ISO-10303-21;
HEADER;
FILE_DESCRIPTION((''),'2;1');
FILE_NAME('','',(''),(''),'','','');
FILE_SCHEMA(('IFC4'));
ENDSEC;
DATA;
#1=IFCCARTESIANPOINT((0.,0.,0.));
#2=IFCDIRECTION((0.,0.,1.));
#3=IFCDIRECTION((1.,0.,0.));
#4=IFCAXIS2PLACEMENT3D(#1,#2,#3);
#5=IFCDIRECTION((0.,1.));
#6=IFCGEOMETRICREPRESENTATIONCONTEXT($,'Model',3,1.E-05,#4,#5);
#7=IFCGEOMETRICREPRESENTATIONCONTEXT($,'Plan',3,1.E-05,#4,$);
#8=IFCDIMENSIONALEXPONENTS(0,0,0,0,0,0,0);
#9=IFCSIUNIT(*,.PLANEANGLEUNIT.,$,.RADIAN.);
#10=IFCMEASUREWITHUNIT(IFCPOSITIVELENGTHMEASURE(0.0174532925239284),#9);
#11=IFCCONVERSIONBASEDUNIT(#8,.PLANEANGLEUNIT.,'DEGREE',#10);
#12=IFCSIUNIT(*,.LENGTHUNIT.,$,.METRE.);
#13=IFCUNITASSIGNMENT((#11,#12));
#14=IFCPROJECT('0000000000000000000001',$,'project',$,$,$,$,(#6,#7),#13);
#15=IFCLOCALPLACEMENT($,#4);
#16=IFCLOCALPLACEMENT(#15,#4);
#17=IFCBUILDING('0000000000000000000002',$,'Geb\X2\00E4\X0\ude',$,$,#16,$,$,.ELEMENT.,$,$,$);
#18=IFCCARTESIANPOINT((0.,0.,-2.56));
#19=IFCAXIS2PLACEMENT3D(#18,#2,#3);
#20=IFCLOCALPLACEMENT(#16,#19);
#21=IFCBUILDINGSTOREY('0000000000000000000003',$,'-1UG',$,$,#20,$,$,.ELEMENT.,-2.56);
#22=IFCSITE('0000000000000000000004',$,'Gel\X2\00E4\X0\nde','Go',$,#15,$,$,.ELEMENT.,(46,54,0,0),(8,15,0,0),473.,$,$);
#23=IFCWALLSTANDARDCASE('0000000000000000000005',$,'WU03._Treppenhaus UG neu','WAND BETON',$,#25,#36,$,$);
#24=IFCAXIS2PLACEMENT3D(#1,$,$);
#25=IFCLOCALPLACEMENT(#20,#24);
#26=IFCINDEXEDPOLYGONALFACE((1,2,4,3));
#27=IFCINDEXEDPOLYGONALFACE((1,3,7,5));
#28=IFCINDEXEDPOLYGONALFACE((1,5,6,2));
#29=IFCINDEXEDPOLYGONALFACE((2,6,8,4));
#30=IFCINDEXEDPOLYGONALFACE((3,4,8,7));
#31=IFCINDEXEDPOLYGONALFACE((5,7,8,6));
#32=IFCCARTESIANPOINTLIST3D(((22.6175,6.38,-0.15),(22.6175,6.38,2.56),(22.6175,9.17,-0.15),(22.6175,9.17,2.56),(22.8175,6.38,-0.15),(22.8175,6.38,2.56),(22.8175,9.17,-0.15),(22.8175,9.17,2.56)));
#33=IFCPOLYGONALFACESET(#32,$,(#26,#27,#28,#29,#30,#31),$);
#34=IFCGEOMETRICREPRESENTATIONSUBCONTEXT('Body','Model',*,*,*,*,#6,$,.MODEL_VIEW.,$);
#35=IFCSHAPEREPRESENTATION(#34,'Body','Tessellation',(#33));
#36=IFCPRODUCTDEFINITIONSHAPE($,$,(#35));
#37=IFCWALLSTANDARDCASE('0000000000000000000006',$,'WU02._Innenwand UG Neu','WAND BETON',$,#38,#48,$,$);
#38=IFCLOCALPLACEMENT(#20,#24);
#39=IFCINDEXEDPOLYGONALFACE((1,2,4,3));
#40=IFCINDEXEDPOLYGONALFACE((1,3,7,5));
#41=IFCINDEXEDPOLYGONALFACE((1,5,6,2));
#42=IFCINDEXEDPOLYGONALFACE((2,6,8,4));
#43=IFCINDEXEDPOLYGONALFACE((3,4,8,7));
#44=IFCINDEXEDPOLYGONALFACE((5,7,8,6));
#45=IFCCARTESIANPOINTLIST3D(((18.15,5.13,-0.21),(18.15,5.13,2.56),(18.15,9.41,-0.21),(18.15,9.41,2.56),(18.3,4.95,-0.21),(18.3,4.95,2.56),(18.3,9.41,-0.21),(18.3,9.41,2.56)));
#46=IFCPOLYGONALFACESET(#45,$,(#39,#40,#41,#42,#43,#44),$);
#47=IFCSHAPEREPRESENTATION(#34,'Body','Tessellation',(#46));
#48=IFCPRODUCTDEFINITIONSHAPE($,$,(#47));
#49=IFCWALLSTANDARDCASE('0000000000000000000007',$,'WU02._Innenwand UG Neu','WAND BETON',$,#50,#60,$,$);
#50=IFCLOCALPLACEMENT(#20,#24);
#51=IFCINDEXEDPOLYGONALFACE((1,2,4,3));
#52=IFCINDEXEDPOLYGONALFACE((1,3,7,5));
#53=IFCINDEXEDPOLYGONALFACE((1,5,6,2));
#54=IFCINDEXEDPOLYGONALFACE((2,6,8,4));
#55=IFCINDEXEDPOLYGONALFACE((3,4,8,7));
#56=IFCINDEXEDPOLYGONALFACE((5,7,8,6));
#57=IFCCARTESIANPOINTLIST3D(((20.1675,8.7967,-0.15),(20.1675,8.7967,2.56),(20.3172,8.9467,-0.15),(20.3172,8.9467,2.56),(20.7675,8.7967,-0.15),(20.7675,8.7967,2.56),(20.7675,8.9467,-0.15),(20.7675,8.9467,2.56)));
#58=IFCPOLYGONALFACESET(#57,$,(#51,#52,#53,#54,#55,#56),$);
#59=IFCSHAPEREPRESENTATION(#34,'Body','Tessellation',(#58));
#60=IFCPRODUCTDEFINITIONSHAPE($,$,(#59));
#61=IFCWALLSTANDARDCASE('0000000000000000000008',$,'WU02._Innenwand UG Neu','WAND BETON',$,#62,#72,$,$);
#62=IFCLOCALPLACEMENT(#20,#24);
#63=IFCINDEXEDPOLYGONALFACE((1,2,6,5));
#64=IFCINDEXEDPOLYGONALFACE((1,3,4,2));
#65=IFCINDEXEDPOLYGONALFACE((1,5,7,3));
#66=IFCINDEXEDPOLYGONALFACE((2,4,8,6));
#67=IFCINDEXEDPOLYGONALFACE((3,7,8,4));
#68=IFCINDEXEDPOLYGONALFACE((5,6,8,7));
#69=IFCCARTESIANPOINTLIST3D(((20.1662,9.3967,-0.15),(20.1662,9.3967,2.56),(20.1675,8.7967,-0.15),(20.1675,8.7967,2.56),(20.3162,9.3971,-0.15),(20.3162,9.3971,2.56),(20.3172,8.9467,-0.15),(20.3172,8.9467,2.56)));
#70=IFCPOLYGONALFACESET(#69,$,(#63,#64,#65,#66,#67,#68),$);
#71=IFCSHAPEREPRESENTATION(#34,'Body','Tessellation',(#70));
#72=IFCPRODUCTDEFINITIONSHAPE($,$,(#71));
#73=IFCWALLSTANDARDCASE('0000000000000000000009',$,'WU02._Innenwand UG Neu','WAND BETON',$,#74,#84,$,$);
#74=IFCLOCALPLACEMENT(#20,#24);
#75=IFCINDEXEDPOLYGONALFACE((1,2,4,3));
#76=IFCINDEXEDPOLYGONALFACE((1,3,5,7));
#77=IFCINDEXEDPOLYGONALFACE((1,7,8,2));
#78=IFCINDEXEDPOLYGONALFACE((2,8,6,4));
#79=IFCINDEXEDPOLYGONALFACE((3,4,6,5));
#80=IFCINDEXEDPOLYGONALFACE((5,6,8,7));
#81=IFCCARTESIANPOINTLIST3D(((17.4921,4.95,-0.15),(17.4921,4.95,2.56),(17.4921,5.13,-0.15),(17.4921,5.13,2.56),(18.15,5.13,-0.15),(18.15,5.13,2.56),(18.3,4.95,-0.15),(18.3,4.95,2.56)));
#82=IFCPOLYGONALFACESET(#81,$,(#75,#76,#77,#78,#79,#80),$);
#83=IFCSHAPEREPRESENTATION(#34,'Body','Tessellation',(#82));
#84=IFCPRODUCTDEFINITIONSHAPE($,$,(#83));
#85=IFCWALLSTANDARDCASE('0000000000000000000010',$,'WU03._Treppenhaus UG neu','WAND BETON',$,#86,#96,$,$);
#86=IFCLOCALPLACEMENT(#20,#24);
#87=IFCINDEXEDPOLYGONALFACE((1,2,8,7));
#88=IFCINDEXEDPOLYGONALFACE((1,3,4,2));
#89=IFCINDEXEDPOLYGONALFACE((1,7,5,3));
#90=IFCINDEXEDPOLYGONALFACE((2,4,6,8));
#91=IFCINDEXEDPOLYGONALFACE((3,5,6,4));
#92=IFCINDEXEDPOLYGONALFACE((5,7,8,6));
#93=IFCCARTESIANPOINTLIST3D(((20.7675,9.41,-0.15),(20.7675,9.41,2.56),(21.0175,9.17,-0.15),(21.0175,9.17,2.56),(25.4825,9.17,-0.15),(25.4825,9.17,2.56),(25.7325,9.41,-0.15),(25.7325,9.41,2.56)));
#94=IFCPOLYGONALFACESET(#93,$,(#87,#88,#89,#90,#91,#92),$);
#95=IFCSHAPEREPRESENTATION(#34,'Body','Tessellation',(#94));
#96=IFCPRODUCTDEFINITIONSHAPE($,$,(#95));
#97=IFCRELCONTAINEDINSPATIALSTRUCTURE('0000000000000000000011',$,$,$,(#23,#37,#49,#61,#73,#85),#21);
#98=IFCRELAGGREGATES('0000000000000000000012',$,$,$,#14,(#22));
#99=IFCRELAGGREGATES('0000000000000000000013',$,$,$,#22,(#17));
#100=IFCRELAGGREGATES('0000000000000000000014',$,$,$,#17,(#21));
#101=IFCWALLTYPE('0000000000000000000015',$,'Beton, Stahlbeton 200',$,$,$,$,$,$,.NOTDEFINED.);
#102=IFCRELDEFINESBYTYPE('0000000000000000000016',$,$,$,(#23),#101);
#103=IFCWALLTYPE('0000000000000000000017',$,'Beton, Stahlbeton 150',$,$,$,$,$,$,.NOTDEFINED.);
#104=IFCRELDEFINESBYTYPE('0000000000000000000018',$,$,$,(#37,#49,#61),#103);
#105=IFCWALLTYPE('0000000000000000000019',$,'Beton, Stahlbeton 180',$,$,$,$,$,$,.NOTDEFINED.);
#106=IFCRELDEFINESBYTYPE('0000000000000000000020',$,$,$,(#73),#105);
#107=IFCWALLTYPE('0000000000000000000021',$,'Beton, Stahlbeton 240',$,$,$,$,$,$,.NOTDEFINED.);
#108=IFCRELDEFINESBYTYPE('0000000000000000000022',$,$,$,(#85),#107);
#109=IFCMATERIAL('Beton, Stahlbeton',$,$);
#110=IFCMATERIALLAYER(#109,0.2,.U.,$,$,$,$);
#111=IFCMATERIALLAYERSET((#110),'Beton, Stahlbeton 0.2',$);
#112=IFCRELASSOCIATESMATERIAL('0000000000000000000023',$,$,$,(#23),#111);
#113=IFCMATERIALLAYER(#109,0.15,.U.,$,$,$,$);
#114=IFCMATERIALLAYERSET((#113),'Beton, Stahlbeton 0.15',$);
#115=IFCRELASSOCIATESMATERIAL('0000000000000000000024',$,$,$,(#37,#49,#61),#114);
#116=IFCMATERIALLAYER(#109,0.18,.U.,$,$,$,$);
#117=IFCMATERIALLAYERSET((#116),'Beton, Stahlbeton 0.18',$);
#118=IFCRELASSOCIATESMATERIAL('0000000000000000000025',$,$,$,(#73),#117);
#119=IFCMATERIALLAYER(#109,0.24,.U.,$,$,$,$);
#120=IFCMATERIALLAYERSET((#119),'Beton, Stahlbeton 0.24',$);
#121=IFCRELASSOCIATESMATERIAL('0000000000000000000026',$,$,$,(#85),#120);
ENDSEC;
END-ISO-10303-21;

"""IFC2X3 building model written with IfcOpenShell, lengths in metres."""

from ifc_helpers import new_model, entity, si_unit, converted_unit, direction, frame, origin_with_axes, place, context, subcontext, project, spatial, polyline, outline, extrude, material, layer, layer_set, layer_usage, type_object, element, save


model = new_model("IFC2X3")

# Units and contexts
model_context = context("Model", 3, precision=1e-05, world=origin_with_axes(), true_north=direction((0.0, 1.0)))
plan_context = context("Plan", 3, precision=1e-05, world=origin_with_axes())
body_context = subcontext(model_context, "Body", "Model", "MODEL_VIEW")
ifc_project = project(units=[converted_unit("PLANEANGLEUNIT", "DEGREE", entity("IfcPositiveLengthMeasure", 0.0174532925239284), si_unit("PLANEANGLEUNIT", "RADIAN"), dimensions=[0, 0, 0, 0, 0, 0, 0]), si_unit("LENGTHUNIT", "METRE")], contexts=[model_context, plan_context])

# Site, building, storey
site_placement = place(None, origin_with_axes())
site = spatial("IfcSite", under=ifc_project, at=site_placement, Name="Gelände", Description="Go", CompositionType="ELEMENT", RefLatitude=(46, 54, 0, 0), RefLongitude=(8, 15, 0, 0), RefElevation=473.0)
building_placement = place(site_placement, origin_with_axes())
building = spatial("IfcBuilding", under=site, at=building_placement, Name="Gebäude", CompositionType="ELEMENT")
storey_placement = place(building_placement, frame((0.0, 0.0, -2.56), z_axis=(0.0, 0.0, 1.0), x_axis=(1.0, 0.0, 0.0)))
storey = spatial("IfcBuildingStorey", under=building, at=storey_placement, Name="-1UG", CompositionType="ELEMENT", Elevation=-2.56)

# Shared definitions
ifc_material_1 = material(Name="Beton, Stahlbeton")

# Walls
ifc_layer_1 = layer(ifc_material_1, 0.2, ventilated="UNKNOWN")
ifc_layer_set_1 = layer_set([ifc_layer_1], Name="Beton, Stahlbeton 0.2")
ifc_layer_usage_1 = layer_usage(ifc_layer_set_1, "AXIS2", "POSITIVE", -0.2)
wall_type_1 = type_object("IfcWallType", Name="Beton, Stahlbeton 200", PredefinedType="NOTDEFINED")
wall_1_placement = place(storey_placement, frame((22.6175, 6.38, -0.15), z_axis=(0.0, 0.0, 1.0), x_axis=(0.0, 1.0, 0.0)))
element("IfcWallStandardCase", 1, at=wall_1_placement, inside=storey, type_object=wall_type_1, material=ifc_layer_usage_1, Name="WU03._Treppenhaus UG neu", Description="WAND BETON", context=body_context, shape_type="SweptSolid", body=[
    extrude(outline(polyline([(0.0, -0.2), (2.79, -0.2), (2.79, 0.0), (0.0, 0.0), (0.0, -0.2)])), origin_with_axes(), (0.0, 0.0, 1.0), 2.71),
])
ifc_layer_2 = layer(ifc_material_1, 0.15, ventilated="UNKNOWN")
ifc_layer_set_2 = layer_set([ifc_layer_2], Name="Beton, Stahlbeton 0.15")
ifc_layer_usage_2 = layer_usage(ifc_layer_set_2, "AXIS2", "NEGATIVE", 0.0)
wall_type_2 = type_object("IfcWallType", Name="Beton, Stahlbeton 150", PredefinedType="NOTDEFINED")
wall_2_placement = place(storey_placement, frame((18.3, 9.41, -0.21), z_axis=(0.0, 0.0, 1.0), x_axis=(0.0, -1.0, 0.0)))
element("IfcWallStandardCase", 2, at=wall_2_placement, inside=storey, type_object=wall_type_2, material=ifc_layer_usage_2, Name="WU02._Innenwand UG Neu", Description="WAND BETON", context=body_context, shape_type="SweptSolid", body=[
    extrude(outline(polyline([(0.0, -0.15), (4.28, -0.15), (4.46, 0.0), (0.0, 0.0), (0.0, -0.15)])), origin_with_axes(), (0.0, 0.0, 1.0), 2.77),
])
ifc_layer_usage_3 = layer_usage(ifc_layer_set_2, "AXIS2", "NEGATIVE", 0.0)
wall_3_placement = place(storey_placement, frame((20.7675, 8.7967, -0.15), z_axis=(0.0, 0.0, 1.0), x_axis=(-1.0, 0.0, 0.0)))
element("IfcWallStandardCase", 3, at=wall_3_placement, inside=storey, type_object=wall_type_2, material=ifc_layer_usage_3, Name="WU02._Innenwand UG Neu", Description="WAND BETON", context=body_context, shape_type="SweptSolid", body=[
    extrude(outline(polyline([(0.0, -0.15), (0.4503, -0.15), (0.6, 0.0), (0.0, 0.0), (0.0, -0.15)])), origin_with_axes(), (0.0, 0.0, 1.0), 2.71),
])
ifc_layer_usage_4 = layer_usage(ifc_layer_set_2, "AXIS2", "NEGATIVE", 0.0)
wall_4_placement = place(storey_placement, frame((20.1675, 8.7967, -0.15), z_axis=(0.0, 0.0, 1.0), x_axis=(-0.002118, 0.999998, 0.0)))
element("IfcWallStandardCase", 4, at=wall_4_placement, inside=storey, type_object=wall_type_2, material=ifc_layer_usage_4, Name="WU02._Innenwand UG Neu", Description="WAND BETON", context=body_context, shape_type="SweptSolid", body=[
    extrude(outline(polyline([(0.1497, -0.15), (0.6, -0.15), (0.6, 0.0), (0.0, 0.0), (0.1497, -0.15)])), origin_with_axes(), (0.0, 0.0, 1.0), 2.71),
])
ifc_layer_3 = layer(ifc_material_1, 0.18, ventilated="UNKNOWN")
ifc_layer_set_3 = layer_set([ifc_layer_3], Name="Beton, Stahlbeton 0.18")
ifc_layer_usage_5 = layer_usage(ifc_layer_set_3, "AXIS2", "NEGATIVE", 0.0)
wall_type_3 = type_object("IfcWallType", Name="Beton, Stahlbeton 180", PredefinedType="NOTDEFINED")
wall_5_placement = place(storey_placement, frame((18.3, 4.95, -0.15), z_axis=(0.0, 0.0, 1.0), x_axis=(-1.0, 0.0, 0.0)))
element("IfcWallStandardCase", 5, at=wall_5_placement, inside=storey, type_object=wall_type_3, material=ifc_layer_usage_5, Name="WU02._Innenwand UG Neu", Description="WAND BETON", context=body_context, shape_type="SweptSolid", body=[
    extrude(outline(polyline([(0.15, -0.18), (0.8079, -0.18), (0.8079, 0.0), (0.0, 0.0), (0.15, -0.18)])), origin_with_axes(), (0.0, 0.0, 1.0), 2.71),
])
ifc_layer_4 = layer(ifc_material_1, 0.24, ventilated="UNKNOWN")
ifc_layer_set_4 = layer_set([ifc_layer_4], Name="Beton, Stahlbeton 0.24")
ifc_layer_usage_6 = layer_usage(ifc_layer_set_4, "AXIS2", "NEGATIVE", 0.24)
wall_type_4 = type_object("IfcWallType", Name="Beton, Stahlbeton 240", PredefinedType="NOTDEFINED")
wall_6_placement = place(storey_placement, frame((21.0175, 9.17, -0.15), z_axis=(0.0, 0.0, 1.0), x_axis=(1.0, 0.0, 0.0)))
element("IfcWallStandardCase", 6, at=wall_6_placement, inside=storey, type_object=wall_type_4, material=ifc_layer_usage_6, Name="WU03._Treppenhaus UG neu", Description="WAND BETON", context=body_context, shape_type="SweptSolid", body=[
    extrude(outline(polyline([(0.0, 0.0), (4.465, 0.0), (4.715, 0.24), (-0.25, 0.24), (0.0, 0.0)])), origin_with_axes(), (0.0, 0.0, 1.0), 2.71),
])

save(model, "model.ifc")
